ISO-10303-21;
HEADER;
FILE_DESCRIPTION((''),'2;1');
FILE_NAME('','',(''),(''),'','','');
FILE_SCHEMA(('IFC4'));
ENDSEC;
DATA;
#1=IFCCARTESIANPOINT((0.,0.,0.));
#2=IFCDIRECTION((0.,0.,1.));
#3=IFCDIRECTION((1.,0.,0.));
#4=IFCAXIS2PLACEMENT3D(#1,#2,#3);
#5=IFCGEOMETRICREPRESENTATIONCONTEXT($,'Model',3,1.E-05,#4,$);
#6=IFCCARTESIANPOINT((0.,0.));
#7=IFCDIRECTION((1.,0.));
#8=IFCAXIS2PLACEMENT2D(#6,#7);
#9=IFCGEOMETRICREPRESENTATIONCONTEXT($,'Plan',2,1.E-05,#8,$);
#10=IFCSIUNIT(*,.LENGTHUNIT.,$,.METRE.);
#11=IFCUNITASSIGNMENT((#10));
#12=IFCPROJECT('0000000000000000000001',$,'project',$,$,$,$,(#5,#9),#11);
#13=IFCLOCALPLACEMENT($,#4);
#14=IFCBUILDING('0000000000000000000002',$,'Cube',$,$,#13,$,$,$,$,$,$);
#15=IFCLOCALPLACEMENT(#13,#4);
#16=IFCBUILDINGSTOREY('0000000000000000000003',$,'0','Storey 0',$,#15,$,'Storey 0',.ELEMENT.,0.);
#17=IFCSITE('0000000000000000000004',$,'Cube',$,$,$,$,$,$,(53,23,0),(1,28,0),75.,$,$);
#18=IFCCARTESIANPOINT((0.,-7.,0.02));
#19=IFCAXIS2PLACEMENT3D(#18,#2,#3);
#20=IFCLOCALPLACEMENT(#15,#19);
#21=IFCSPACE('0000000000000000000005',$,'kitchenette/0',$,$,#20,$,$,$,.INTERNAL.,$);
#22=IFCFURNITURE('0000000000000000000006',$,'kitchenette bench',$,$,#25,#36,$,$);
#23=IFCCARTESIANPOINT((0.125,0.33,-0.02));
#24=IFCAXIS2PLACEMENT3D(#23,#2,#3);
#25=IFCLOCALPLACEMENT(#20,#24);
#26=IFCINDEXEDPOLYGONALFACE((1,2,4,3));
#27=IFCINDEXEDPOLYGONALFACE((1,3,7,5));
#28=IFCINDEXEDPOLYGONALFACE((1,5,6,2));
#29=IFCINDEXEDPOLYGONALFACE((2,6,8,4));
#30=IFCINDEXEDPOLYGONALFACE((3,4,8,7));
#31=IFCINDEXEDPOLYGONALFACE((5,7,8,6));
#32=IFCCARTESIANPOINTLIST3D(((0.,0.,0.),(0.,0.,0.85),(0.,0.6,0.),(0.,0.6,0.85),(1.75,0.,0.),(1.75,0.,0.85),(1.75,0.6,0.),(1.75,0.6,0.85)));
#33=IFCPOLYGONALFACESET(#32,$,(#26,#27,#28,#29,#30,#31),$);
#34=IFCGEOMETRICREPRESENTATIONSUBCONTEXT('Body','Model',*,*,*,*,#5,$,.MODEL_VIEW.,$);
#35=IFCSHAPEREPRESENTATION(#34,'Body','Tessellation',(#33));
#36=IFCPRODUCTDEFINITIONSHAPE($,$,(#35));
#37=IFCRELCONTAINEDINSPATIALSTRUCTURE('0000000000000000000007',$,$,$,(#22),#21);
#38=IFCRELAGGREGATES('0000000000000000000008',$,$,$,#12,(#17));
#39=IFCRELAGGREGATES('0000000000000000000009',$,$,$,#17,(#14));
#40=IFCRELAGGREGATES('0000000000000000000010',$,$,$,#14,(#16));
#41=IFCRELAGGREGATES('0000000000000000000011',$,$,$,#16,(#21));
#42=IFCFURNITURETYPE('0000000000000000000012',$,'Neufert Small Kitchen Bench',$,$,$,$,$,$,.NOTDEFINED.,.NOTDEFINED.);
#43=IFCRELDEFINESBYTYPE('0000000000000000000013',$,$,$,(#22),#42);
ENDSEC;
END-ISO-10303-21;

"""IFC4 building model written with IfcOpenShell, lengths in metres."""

from ifc_helpers import new_model, entity, si_unit, frame, origin_with_axes, origin_2d_with_axis, place, context, subcontext, project, spatial, line, indexed_curve, outline, extrude, shape, source, transform, mapped, type_object, type_shapes, element, save


model = new_model("IFC4")

# Units and contexts
model_context = context("Model", 3, precision=1e-05, world=origin_with_axes())
plan_context = context("Plan", 2, precision=1e-05, world=origin_2d_with_axis())
body_context_1 = subcontext(model_context, "Body", "Model", "MODEL_VIEW")
body_context_2 = subcontext(plan_context, "Body", "Plan", "PLAN_VIEW")
ifc_project = project(units=[si_unit("LENGTHUNIT", "METRE")], contexts=[model_context, plan_context])

# Site, building, storey
site = spatial("IfcSite", under=ifc_project, Name="Cube", RefLatitude=(53, 23, 0), RefLongitude=(1, 28, 0), RefElevation=75.0)
building_placement = place(None, origin_with_axes())
building = spatial("IfcBuilding", under=site, at=building_placement, Name="Cube")
storey_placement = place(building_placement, origin_with_axes())
storey = spatial("IfcBuildingStorey", under=building, at=storey_placement, Name="0", Description="Storey 0", LongName="Storey 0", CompositionType="ELEMENT", Elevation=0.0)

# Shared definitions
space_1_placement = place(storey_placement, frame((0.0, -7.0, 0.02), z_axis=(0.0, 0.0, 1.0), x_axis=(1.0, 0.0, 0.0)))
space_1 = spatial("IfcSpace", under=storey, at=space_1_placement, Name="kitchenette/0", PredefinedType="INTERNAL")

# Furniture
furniture_type_1 = type_object("IfcFurnitureType", Name="Neufert Small Kitchen Bench", AssemblyPlace="NOTDEFINED", PredefinedType="NOTDEFINED")
shared_shape_1 = source(origin_with_axes(), body_context_1, "Body", "SweptSolid", [
    extrude(outline(indexed_curve([(0.0, 0.0), (1.75, 0.0), (1.75, 0.6), (0.0, 0.6)], segments=[line(1, 2, 3, 4, 1)])), origin_with_axes(), (0.0, 0.0, 1.0), 0.85),
])
shared_shape_2 = source(origin_with_axes(), body_context_2, "Body", "Curve2D", [
    entity("IfcIndexedPolyCurve", entity("IfcCartesianPointList2D", [[0.0, 0.0], [1.75, 0.0], [1.75, 0.6], [0.0, 0.6]]), [entity("IfcLineIndex", [1, 2, 3, 4, 1])]),
])
type_shapes(furniture_type_1, [shared_shape_1, shared_shape_2])
furniture_placement = place(space_1_placement, frame((0.125, 0.33, -0.02), z_axis=(0.0, 0.0, 1.0), x_axis=(1.0, 0.0, 0.0)))
element("IfcFurniture", 1, at=furniture_placement, inside=space_1, type_object=furniture_type_1, Name="kitchenette bench", shapes=[
    shape(body_context_1, "Body", "MappedRepresentation", [mapped(shared_shape_1, transform((0.0, 0.0, 0.0), x_axis=(1.0, 0.0, 0.0), y_axis=(0.0, 1.0, 0.0), z_axis=(0.0, 0.0, 1.0), scale=1.0))]),
    shape(body_context_2, "Body", "MappedRepresentation", [mapped(shared_shape_2, transform((0.0, 0.0, 0.0), x_axis=(1.0, 0.0, 0.0), y_axis=(0.0, 1.0, 0.0), z_axis=(0.0, 0.0, 1.0), scale=1.0))]),
])

save(model, "model.ifc")
